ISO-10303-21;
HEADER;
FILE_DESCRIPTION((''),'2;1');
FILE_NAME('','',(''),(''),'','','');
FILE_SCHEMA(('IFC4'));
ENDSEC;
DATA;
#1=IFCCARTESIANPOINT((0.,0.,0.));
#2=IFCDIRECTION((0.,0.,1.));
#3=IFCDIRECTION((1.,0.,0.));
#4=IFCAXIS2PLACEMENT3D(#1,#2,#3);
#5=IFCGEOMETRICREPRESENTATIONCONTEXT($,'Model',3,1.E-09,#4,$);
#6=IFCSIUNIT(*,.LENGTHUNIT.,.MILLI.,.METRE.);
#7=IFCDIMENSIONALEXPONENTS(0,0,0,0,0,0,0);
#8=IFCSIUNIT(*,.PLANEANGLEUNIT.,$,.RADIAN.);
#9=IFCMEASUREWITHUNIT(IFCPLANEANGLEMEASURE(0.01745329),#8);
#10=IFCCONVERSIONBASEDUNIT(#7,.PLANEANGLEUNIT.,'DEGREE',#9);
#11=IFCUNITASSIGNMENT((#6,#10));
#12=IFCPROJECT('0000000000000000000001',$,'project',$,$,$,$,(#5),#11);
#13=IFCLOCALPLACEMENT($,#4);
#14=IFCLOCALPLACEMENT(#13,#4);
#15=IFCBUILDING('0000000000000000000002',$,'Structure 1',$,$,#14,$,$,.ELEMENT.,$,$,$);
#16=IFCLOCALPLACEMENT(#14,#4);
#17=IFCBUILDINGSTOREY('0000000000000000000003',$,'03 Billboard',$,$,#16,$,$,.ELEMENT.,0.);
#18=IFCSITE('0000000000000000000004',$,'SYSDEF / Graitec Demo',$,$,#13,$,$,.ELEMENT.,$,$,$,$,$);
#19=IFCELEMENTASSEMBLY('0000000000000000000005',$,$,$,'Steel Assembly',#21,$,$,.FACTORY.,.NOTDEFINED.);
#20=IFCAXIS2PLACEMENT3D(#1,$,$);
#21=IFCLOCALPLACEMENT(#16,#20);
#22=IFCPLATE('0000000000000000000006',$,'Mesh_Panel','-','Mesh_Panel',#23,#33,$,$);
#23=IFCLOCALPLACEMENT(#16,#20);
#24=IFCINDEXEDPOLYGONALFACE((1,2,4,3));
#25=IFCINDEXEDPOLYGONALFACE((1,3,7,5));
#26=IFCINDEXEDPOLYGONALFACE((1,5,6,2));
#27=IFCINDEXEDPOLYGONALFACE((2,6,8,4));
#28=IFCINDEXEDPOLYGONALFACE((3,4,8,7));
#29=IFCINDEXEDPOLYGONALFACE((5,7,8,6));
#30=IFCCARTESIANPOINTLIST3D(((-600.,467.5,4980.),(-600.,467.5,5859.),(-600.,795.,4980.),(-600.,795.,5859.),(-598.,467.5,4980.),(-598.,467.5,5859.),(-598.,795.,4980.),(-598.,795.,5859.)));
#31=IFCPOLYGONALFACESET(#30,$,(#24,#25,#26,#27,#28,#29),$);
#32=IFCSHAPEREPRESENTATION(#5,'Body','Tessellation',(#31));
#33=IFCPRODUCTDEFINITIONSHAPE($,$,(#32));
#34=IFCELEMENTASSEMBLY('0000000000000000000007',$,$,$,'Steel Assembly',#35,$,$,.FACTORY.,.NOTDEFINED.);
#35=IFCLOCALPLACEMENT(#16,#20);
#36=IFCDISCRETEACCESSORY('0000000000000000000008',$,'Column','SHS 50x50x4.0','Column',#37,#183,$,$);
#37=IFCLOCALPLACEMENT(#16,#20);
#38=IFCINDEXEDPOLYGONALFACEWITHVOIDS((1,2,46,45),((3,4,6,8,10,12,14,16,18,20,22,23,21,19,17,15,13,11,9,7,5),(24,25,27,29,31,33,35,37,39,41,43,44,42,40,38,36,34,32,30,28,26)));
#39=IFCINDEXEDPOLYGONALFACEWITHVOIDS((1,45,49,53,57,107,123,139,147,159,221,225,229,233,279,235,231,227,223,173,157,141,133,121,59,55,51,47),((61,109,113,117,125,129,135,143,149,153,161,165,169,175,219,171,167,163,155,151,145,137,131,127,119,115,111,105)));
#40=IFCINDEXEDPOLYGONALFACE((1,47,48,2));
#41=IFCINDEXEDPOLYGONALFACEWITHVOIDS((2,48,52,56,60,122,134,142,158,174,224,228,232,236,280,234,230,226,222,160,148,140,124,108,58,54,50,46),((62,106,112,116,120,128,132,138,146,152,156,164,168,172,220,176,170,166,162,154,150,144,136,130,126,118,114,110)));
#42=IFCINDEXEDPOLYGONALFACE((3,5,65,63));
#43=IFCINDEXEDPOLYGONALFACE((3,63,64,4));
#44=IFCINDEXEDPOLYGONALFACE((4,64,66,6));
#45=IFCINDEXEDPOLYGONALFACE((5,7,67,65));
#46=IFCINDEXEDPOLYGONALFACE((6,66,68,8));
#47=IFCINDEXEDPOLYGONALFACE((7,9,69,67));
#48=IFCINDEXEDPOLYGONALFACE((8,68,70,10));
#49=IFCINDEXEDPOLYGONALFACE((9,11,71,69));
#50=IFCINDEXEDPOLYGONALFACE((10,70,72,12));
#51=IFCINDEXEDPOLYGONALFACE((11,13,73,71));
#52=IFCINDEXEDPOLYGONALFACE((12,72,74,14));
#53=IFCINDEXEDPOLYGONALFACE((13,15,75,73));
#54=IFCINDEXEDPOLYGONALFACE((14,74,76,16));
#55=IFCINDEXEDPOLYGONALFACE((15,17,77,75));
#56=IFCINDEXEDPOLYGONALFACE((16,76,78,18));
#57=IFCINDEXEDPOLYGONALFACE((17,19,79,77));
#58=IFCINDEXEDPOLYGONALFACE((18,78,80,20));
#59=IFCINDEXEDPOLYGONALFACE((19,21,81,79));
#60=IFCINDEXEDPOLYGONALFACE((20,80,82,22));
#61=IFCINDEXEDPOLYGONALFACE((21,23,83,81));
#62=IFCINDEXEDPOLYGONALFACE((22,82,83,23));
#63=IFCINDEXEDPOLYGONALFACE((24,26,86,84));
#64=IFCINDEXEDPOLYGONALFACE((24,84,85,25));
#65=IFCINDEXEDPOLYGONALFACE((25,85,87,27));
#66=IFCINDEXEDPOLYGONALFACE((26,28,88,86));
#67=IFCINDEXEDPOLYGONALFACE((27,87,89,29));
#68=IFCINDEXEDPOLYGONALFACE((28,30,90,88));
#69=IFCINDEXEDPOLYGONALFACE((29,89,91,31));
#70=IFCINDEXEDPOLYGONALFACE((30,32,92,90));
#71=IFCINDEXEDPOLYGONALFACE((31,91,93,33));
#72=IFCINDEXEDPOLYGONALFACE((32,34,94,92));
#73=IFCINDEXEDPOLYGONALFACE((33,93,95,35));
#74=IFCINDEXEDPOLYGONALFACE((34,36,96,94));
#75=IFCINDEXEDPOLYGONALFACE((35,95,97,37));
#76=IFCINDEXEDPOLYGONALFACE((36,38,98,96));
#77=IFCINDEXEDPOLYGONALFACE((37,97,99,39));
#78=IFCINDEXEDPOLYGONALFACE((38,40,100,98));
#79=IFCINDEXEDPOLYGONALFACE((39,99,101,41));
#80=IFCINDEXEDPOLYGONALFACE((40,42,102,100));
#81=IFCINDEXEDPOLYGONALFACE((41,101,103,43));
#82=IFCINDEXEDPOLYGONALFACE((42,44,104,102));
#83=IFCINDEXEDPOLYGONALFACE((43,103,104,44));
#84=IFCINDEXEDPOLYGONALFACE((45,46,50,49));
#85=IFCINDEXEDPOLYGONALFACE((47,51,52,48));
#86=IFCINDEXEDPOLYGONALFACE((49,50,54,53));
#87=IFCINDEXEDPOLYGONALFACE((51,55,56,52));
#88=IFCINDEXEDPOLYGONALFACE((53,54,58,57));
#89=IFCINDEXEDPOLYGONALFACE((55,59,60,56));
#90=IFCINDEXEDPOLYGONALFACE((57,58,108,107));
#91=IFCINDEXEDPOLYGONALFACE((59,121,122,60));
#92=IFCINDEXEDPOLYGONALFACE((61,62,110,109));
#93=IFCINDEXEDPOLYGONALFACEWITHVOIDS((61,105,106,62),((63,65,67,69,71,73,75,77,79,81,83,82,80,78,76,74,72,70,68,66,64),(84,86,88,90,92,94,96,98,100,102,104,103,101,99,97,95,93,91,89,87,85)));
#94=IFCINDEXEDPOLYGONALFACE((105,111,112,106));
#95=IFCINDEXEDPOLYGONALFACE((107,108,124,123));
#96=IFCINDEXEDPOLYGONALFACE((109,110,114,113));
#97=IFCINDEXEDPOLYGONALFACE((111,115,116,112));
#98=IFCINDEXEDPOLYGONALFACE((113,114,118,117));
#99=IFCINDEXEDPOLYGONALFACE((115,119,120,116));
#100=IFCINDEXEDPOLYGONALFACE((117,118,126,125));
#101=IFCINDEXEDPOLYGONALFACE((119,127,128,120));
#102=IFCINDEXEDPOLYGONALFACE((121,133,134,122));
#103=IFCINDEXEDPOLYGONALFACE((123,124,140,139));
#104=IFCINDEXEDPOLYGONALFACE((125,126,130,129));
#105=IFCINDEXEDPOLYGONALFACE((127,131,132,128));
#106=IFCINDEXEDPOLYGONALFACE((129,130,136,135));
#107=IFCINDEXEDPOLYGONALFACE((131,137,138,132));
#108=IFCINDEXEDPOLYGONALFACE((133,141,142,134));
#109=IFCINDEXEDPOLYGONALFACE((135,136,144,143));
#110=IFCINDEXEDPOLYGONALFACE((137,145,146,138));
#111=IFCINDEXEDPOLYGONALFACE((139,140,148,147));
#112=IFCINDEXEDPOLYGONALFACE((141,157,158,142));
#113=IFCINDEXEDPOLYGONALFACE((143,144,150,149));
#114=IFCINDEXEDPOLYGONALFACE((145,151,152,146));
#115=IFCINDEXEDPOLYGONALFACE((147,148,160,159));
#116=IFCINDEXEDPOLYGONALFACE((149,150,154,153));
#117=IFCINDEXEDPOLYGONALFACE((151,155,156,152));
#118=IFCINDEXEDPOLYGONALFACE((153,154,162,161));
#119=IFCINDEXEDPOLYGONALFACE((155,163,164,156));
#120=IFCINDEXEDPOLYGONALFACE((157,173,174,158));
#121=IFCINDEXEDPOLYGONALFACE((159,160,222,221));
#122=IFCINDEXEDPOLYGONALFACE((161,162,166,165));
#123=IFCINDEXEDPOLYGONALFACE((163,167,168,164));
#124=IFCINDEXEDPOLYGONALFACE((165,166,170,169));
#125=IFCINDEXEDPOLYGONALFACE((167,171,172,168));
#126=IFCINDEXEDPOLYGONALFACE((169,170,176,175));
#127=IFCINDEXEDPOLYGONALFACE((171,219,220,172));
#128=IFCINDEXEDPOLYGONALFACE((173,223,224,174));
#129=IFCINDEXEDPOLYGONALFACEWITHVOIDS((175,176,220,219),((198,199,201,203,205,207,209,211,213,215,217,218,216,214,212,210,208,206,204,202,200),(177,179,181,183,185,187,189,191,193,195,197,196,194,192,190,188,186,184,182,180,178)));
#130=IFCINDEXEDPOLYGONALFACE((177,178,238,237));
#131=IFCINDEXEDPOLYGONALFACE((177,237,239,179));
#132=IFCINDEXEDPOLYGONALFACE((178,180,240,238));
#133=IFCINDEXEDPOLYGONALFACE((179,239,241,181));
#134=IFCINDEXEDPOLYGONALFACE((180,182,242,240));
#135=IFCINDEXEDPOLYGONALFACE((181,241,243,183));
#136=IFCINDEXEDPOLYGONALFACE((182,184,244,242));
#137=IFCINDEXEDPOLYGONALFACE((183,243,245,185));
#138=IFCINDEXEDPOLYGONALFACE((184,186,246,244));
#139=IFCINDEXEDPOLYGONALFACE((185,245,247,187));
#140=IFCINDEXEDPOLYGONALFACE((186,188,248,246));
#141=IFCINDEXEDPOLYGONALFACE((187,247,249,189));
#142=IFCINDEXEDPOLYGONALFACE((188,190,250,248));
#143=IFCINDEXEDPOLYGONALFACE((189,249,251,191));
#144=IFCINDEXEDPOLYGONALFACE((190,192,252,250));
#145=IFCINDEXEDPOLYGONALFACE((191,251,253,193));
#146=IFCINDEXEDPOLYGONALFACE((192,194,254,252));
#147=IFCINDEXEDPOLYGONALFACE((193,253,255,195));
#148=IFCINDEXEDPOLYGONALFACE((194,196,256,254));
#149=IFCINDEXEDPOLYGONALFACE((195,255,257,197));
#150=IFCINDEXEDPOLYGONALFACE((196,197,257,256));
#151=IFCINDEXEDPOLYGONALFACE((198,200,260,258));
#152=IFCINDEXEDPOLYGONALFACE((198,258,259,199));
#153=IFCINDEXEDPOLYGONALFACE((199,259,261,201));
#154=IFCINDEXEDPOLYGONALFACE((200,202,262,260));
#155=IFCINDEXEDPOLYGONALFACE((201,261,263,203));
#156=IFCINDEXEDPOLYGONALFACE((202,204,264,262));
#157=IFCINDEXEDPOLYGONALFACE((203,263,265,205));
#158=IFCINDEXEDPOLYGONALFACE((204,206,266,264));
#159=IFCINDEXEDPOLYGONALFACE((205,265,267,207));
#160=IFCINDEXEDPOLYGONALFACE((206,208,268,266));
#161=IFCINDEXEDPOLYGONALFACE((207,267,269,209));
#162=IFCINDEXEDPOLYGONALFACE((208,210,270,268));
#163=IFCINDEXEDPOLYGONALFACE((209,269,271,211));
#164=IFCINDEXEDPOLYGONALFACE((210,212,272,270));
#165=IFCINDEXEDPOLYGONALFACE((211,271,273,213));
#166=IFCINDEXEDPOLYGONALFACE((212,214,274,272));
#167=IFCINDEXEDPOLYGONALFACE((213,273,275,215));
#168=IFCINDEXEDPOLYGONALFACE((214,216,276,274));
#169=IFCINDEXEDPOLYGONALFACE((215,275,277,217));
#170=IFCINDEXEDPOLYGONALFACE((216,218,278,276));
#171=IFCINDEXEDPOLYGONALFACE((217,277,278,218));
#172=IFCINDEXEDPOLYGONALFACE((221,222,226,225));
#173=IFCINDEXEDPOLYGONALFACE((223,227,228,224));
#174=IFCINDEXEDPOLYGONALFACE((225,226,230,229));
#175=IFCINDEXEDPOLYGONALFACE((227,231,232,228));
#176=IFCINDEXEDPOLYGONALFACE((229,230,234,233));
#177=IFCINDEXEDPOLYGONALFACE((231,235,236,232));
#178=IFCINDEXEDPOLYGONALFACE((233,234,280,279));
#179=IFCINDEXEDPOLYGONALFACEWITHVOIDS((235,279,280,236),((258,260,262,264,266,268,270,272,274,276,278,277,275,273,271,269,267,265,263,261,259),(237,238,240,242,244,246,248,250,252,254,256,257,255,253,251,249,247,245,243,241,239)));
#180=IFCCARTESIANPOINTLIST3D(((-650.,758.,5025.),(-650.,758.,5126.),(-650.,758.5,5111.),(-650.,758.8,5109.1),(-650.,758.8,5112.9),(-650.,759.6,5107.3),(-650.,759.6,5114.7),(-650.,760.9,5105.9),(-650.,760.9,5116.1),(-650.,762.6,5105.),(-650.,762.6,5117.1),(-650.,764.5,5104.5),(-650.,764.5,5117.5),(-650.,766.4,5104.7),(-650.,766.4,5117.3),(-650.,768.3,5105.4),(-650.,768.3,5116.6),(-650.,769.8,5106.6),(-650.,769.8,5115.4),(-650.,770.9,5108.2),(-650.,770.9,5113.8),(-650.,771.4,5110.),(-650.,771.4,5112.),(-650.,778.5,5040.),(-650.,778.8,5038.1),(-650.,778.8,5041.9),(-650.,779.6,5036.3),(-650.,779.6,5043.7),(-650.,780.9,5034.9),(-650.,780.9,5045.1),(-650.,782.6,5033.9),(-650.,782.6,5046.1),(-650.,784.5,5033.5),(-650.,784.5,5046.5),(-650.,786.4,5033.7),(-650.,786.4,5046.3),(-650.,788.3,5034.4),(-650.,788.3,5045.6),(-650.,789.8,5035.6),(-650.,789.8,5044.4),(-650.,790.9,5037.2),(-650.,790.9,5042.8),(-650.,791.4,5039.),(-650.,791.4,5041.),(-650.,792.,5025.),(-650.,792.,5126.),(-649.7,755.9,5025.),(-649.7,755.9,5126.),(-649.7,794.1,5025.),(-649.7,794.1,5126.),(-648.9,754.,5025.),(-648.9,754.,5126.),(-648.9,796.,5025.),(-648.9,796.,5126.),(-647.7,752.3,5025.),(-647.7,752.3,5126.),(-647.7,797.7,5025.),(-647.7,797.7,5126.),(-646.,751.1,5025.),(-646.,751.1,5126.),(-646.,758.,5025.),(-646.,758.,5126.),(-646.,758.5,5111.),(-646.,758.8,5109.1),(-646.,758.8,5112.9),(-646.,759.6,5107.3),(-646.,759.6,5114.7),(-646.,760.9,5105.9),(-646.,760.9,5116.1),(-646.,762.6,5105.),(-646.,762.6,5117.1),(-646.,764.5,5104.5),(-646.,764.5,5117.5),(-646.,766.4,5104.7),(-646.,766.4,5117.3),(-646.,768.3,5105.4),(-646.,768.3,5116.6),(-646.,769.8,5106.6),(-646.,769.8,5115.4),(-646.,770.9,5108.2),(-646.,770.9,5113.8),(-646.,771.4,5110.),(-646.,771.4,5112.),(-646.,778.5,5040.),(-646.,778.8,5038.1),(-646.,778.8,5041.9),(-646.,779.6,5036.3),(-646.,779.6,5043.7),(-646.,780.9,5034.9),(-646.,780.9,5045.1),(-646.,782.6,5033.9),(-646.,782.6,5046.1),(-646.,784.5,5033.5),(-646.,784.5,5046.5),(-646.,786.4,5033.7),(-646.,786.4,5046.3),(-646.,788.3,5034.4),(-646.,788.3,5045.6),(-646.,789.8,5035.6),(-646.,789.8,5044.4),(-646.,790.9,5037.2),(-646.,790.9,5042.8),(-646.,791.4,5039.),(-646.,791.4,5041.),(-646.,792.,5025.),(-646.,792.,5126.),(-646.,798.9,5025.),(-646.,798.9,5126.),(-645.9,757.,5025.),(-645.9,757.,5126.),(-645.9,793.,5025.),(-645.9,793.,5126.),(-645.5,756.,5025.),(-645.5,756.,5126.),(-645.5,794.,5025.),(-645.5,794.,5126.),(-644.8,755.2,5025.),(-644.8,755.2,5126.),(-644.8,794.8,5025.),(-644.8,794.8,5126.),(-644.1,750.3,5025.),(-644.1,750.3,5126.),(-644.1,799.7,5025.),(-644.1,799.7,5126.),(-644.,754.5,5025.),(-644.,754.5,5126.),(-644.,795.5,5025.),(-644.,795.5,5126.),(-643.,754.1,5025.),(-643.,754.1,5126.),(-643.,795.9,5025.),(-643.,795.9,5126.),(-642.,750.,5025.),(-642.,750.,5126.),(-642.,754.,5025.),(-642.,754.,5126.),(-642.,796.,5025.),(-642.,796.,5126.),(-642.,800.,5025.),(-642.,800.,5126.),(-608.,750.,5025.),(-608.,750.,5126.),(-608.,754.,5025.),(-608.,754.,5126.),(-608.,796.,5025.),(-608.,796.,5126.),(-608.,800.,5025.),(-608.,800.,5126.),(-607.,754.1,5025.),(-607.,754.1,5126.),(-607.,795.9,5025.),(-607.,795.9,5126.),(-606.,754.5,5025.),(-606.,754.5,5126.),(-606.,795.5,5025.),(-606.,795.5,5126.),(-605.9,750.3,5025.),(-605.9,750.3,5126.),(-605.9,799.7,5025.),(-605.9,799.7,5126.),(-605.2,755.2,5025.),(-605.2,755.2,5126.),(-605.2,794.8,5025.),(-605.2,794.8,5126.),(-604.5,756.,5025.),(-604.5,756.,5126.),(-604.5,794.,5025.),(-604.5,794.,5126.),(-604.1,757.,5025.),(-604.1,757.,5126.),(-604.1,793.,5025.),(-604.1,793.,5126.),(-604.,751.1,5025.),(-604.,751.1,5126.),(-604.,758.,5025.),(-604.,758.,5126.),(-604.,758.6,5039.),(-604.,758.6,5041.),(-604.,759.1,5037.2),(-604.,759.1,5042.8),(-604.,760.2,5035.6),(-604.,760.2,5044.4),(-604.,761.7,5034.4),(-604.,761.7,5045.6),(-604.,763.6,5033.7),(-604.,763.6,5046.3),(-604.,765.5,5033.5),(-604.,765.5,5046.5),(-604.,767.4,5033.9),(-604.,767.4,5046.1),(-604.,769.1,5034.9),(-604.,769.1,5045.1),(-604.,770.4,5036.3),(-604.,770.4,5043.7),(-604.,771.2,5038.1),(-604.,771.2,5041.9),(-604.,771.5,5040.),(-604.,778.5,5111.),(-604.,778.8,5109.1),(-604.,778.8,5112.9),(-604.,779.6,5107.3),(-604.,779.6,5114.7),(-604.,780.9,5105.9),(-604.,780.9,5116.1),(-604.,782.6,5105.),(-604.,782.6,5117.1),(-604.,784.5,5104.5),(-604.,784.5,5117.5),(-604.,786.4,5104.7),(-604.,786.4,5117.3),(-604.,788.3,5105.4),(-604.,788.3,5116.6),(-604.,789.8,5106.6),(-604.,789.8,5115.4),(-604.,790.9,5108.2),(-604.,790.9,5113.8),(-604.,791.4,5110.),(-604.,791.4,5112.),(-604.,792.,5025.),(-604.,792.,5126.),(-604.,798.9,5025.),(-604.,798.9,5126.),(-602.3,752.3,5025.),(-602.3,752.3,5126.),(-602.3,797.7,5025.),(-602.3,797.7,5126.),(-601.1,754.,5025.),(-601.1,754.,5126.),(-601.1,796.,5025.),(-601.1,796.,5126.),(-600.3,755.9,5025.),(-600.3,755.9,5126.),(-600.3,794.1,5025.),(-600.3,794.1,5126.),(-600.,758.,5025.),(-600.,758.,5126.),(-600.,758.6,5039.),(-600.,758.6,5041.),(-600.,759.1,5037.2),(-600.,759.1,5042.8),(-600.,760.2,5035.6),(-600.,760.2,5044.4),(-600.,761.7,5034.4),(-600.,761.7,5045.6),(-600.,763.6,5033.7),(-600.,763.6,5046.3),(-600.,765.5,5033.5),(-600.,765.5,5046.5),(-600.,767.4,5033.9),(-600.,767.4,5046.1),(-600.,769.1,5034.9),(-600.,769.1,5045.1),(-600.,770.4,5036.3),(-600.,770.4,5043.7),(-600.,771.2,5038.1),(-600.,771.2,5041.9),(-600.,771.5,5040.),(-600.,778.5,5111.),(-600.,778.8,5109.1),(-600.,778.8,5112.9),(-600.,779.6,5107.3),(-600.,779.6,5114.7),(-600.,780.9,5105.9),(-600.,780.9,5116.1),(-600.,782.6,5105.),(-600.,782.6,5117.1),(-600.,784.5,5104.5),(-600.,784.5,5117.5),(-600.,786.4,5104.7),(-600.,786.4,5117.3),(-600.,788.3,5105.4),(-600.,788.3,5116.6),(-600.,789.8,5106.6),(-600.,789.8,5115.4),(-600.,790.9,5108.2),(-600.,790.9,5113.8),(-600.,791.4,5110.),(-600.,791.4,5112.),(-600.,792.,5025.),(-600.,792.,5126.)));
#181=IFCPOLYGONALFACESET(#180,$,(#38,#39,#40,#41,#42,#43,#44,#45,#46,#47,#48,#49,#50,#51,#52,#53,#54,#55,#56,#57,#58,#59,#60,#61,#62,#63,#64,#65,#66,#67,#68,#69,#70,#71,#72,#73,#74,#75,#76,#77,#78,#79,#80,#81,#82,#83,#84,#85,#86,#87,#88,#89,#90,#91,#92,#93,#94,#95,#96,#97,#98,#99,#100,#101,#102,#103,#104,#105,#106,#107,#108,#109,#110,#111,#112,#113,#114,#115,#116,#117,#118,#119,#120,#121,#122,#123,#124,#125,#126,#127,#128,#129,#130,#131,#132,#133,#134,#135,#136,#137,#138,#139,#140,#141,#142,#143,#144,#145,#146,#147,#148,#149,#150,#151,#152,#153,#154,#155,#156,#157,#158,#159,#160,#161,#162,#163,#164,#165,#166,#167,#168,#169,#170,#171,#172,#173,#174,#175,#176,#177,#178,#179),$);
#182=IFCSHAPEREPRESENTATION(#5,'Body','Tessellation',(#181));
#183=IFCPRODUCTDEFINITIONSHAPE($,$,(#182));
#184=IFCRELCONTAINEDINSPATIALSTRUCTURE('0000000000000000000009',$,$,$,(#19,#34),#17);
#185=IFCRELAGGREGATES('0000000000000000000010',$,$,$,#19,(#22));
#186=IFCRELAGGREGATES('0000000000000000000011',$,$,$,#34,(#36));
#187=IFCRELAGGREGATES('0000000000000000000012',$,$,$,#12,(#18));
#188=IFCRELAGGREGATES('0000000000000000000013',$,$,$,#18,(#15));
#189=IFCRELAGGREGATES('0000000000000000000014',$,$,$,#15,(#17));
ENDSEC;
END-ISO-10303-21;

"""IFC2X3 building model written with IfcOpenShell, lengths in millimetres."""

from ifc_helpers import new_model, entity, si_unit, converted_unit, frame, frame_2d, origin, origin_with_axes, origin_2d, origin_2d_with_axis, place, context, project, spatial, polyline, hollow_rectangle, circle, outline, extrude, clip, halfspace, element, aggregate, save


model = new_model("IFC2X3")

# Units and contexts
model_context = context("Model", 3, precision=1e-09, world=origin_with_axes())
ifc_project = project(units=[si_unit("LENGTHUNIT", "METRE", prefix="MILLI"), converted_unit("PLANEANGLEUNIT", "DEGREE", entity("IfcPlaneAngleMeasure", 0.01745329), si_unit("PLANEANGLEUNIT", "RADIAN"), dimensions=[0, 0, 0, 0, 0, 0, 0])], contexts=[model_context])

# Site, building, storey
site_placement = place(None, origin_with_axes())
site = spatial("IfcSite", under=ifc_project, at=site_placement, Name="SYSDEF / Graitec Demo", CompositionType="ELEMENT")
building_placement = place(site_placement, origin_with_axes())
building = spatial("IfcBuilding", under=site, at=building_placement, Name="Structure 1", CompositionType="ELEMENT")
storey_placement = place(building_placement, origin_with_axes())
storey = spatial("IfcBuildingStorey", under=building, at=storey_placement, Name="03 Billboard", CompositionType="ELEMENT", Elevation=0.0)

# Element assembly, plate
assembly_1_placement = place(None, frame((-598.0, 631.3, 5419.5), z_axis=(-1.0, 0.0, 0.0), x_axis=(0.0, 1.0, 0.0)))
assembly_1 = element("IfcElementAssembly", 1, at=assembly_1_placement, inside=storey, ObjectType="Steel Assembly", AssemblyPlace="FACTORY", PredefinedType="NOTDEFINED")
plate_placement = place(assembly_1_placement, origin_with_axes())
plate = element("IfcPlate", 2, at=plate_placement, Name="Mesh_Panel", Description="-", ObjectType="Mesh_Panel", context=model_context, shape_type="SweptSolid", body=[
    extrude(outline(polyline([(-163.7, -439.5), (163.7, -439.5), (163.7, 439.5), (-163.7, 439.5), (-163.7, -439.5)])), origin_with_axes(), (0.0, 0.0, 1.0), 2.0),
])
aggregate(assembly_1, [plate])

# Element assembly, discrete accessory, openings
assembly_2_placement = place(None, frame((-4239.1, -387.5, 4000.0), z_axis=(-1.0, 0.0, 0.0), x_axis=(0.0, 0.0, 1.0)))
assembly_2 = element("IfcElementAssembly", 3, at=assembly_2_placement, inside=storey, ObjectType="Steel Assembly", AssemblyPlace="FACTORY", PredefinedType="NOTDEFINED")
discrete_accessory_1_placement = place(assembly_2_placement, frame((1186.4, 1162.5, -3614.1), z_axis=(1.0, 0.0, 0.0), x_axis=(0.0, 0.0, -1.0)))
discrete_accessory_1 = element("IfcDiscreteAccessory", 4, at=discrete_accessory_1_placement, Name="Column", Description="SHS 50x50x4.0", ObjectType="Column", context=model_context, shape_type="Clipping", body=[
    clip(clip(extrude(hollow_rectangle(XDim=50.0, YDim=50.0, WallThickness=4.0, InnerFilletRadius=4.0, OuterFilletRadius=8.0, at=origin_2d()), origin(), (0.0, 0.0, -1.0), 196.7), halfspace(frame((625.0, -775.0, -161.4), z_axis=(0.0, 0.0, 1.0), x_axis=(1.0, 0.0, 0.0)), True)), halfspace(frame((625.0, -775.0, -60.4), z_axis=(0.0, 0.0, -1.0), x_axis=(-1.0, 0.0, 0.0)), True)),
])
opening_1_placement = place(discrete_accessory_1_placement, frame((-25.5, 16.5, -146.4), z_axis=(-1.0, 0.0, 0.0), x_axis=(0.0, -1.0, 0.0)))
element("IfcOpeningElement", 5, at=opening_1_placement, cuts=discrete_accessory_1, ObjectType="Opening", context=model_context, shape_type="SweptSolid", body=[
    extrude(circle(Radius=6.5, at=frame_2d((6.5, 0.0), x_axis=(1.0, 0.0))), origin(), (0.0, 0.0, -1.0), 5.0),
])
opening_2_placement = place(discrete_accessory_1_placement, frame((20.5, -10.0, -146.4), z_axis=(1.0, 0.0, 0.0), x_axis=(0.0, 1.0, 0.0)))
element("IfcOpeningElement", 6, at=opening_2_placement, cuts=discrete_accessory_1, ObjectType="Opening", context=model_context, shape_type="SweptSolid", body=[
    extrude(circle(Radius=6.5, at=origin_2d_with_axis()), origin(), (0.0, 0.0, 1.0), 5.0),
])
opening_3_placement = place(discrete_accessory_1_placement, frame((-25.5, -16.5, -75.4), z_axis=(-1.0, 0.0, 0.0), x_axis=(0.0, -1.0, 0.0)))
element("IfcOpeningElement", 7, at=opening_3_placement, cuts=discrete_accessory_1, ObjectType="Opening", context=model_context, shape_type="SweptSolid", body=[
    extrude(circle(Radius=6.5, at=frame_2d((-6.5, 0.0), x_axis=(1.0, 0.0))), origin(), (0.0, 0.0, -1.0), 5.0),
])
opening_4_placement = place(discrete_accessory_1_placement, frame((20.5, 10.0, -75.4), z_axis=(1.0, 0.0, 0.0), x_axis=(0.0, -1.0, 0.0)))
element("IfcOpeningElement", 8, at=opening_4_placement, cuts=discrete_accessory_1, ObjectType="Opening", context=model_context, shape_type="SweptSolid", body=[
    extrude(circle(Radius=6.5, at=origin_2d_with_axis()), origin(), (0.0, 0.0, 1.0), 5.0),
])
aggregate(assembly_2, [discrete_accessory_1])

save(model, "model.ifc")
